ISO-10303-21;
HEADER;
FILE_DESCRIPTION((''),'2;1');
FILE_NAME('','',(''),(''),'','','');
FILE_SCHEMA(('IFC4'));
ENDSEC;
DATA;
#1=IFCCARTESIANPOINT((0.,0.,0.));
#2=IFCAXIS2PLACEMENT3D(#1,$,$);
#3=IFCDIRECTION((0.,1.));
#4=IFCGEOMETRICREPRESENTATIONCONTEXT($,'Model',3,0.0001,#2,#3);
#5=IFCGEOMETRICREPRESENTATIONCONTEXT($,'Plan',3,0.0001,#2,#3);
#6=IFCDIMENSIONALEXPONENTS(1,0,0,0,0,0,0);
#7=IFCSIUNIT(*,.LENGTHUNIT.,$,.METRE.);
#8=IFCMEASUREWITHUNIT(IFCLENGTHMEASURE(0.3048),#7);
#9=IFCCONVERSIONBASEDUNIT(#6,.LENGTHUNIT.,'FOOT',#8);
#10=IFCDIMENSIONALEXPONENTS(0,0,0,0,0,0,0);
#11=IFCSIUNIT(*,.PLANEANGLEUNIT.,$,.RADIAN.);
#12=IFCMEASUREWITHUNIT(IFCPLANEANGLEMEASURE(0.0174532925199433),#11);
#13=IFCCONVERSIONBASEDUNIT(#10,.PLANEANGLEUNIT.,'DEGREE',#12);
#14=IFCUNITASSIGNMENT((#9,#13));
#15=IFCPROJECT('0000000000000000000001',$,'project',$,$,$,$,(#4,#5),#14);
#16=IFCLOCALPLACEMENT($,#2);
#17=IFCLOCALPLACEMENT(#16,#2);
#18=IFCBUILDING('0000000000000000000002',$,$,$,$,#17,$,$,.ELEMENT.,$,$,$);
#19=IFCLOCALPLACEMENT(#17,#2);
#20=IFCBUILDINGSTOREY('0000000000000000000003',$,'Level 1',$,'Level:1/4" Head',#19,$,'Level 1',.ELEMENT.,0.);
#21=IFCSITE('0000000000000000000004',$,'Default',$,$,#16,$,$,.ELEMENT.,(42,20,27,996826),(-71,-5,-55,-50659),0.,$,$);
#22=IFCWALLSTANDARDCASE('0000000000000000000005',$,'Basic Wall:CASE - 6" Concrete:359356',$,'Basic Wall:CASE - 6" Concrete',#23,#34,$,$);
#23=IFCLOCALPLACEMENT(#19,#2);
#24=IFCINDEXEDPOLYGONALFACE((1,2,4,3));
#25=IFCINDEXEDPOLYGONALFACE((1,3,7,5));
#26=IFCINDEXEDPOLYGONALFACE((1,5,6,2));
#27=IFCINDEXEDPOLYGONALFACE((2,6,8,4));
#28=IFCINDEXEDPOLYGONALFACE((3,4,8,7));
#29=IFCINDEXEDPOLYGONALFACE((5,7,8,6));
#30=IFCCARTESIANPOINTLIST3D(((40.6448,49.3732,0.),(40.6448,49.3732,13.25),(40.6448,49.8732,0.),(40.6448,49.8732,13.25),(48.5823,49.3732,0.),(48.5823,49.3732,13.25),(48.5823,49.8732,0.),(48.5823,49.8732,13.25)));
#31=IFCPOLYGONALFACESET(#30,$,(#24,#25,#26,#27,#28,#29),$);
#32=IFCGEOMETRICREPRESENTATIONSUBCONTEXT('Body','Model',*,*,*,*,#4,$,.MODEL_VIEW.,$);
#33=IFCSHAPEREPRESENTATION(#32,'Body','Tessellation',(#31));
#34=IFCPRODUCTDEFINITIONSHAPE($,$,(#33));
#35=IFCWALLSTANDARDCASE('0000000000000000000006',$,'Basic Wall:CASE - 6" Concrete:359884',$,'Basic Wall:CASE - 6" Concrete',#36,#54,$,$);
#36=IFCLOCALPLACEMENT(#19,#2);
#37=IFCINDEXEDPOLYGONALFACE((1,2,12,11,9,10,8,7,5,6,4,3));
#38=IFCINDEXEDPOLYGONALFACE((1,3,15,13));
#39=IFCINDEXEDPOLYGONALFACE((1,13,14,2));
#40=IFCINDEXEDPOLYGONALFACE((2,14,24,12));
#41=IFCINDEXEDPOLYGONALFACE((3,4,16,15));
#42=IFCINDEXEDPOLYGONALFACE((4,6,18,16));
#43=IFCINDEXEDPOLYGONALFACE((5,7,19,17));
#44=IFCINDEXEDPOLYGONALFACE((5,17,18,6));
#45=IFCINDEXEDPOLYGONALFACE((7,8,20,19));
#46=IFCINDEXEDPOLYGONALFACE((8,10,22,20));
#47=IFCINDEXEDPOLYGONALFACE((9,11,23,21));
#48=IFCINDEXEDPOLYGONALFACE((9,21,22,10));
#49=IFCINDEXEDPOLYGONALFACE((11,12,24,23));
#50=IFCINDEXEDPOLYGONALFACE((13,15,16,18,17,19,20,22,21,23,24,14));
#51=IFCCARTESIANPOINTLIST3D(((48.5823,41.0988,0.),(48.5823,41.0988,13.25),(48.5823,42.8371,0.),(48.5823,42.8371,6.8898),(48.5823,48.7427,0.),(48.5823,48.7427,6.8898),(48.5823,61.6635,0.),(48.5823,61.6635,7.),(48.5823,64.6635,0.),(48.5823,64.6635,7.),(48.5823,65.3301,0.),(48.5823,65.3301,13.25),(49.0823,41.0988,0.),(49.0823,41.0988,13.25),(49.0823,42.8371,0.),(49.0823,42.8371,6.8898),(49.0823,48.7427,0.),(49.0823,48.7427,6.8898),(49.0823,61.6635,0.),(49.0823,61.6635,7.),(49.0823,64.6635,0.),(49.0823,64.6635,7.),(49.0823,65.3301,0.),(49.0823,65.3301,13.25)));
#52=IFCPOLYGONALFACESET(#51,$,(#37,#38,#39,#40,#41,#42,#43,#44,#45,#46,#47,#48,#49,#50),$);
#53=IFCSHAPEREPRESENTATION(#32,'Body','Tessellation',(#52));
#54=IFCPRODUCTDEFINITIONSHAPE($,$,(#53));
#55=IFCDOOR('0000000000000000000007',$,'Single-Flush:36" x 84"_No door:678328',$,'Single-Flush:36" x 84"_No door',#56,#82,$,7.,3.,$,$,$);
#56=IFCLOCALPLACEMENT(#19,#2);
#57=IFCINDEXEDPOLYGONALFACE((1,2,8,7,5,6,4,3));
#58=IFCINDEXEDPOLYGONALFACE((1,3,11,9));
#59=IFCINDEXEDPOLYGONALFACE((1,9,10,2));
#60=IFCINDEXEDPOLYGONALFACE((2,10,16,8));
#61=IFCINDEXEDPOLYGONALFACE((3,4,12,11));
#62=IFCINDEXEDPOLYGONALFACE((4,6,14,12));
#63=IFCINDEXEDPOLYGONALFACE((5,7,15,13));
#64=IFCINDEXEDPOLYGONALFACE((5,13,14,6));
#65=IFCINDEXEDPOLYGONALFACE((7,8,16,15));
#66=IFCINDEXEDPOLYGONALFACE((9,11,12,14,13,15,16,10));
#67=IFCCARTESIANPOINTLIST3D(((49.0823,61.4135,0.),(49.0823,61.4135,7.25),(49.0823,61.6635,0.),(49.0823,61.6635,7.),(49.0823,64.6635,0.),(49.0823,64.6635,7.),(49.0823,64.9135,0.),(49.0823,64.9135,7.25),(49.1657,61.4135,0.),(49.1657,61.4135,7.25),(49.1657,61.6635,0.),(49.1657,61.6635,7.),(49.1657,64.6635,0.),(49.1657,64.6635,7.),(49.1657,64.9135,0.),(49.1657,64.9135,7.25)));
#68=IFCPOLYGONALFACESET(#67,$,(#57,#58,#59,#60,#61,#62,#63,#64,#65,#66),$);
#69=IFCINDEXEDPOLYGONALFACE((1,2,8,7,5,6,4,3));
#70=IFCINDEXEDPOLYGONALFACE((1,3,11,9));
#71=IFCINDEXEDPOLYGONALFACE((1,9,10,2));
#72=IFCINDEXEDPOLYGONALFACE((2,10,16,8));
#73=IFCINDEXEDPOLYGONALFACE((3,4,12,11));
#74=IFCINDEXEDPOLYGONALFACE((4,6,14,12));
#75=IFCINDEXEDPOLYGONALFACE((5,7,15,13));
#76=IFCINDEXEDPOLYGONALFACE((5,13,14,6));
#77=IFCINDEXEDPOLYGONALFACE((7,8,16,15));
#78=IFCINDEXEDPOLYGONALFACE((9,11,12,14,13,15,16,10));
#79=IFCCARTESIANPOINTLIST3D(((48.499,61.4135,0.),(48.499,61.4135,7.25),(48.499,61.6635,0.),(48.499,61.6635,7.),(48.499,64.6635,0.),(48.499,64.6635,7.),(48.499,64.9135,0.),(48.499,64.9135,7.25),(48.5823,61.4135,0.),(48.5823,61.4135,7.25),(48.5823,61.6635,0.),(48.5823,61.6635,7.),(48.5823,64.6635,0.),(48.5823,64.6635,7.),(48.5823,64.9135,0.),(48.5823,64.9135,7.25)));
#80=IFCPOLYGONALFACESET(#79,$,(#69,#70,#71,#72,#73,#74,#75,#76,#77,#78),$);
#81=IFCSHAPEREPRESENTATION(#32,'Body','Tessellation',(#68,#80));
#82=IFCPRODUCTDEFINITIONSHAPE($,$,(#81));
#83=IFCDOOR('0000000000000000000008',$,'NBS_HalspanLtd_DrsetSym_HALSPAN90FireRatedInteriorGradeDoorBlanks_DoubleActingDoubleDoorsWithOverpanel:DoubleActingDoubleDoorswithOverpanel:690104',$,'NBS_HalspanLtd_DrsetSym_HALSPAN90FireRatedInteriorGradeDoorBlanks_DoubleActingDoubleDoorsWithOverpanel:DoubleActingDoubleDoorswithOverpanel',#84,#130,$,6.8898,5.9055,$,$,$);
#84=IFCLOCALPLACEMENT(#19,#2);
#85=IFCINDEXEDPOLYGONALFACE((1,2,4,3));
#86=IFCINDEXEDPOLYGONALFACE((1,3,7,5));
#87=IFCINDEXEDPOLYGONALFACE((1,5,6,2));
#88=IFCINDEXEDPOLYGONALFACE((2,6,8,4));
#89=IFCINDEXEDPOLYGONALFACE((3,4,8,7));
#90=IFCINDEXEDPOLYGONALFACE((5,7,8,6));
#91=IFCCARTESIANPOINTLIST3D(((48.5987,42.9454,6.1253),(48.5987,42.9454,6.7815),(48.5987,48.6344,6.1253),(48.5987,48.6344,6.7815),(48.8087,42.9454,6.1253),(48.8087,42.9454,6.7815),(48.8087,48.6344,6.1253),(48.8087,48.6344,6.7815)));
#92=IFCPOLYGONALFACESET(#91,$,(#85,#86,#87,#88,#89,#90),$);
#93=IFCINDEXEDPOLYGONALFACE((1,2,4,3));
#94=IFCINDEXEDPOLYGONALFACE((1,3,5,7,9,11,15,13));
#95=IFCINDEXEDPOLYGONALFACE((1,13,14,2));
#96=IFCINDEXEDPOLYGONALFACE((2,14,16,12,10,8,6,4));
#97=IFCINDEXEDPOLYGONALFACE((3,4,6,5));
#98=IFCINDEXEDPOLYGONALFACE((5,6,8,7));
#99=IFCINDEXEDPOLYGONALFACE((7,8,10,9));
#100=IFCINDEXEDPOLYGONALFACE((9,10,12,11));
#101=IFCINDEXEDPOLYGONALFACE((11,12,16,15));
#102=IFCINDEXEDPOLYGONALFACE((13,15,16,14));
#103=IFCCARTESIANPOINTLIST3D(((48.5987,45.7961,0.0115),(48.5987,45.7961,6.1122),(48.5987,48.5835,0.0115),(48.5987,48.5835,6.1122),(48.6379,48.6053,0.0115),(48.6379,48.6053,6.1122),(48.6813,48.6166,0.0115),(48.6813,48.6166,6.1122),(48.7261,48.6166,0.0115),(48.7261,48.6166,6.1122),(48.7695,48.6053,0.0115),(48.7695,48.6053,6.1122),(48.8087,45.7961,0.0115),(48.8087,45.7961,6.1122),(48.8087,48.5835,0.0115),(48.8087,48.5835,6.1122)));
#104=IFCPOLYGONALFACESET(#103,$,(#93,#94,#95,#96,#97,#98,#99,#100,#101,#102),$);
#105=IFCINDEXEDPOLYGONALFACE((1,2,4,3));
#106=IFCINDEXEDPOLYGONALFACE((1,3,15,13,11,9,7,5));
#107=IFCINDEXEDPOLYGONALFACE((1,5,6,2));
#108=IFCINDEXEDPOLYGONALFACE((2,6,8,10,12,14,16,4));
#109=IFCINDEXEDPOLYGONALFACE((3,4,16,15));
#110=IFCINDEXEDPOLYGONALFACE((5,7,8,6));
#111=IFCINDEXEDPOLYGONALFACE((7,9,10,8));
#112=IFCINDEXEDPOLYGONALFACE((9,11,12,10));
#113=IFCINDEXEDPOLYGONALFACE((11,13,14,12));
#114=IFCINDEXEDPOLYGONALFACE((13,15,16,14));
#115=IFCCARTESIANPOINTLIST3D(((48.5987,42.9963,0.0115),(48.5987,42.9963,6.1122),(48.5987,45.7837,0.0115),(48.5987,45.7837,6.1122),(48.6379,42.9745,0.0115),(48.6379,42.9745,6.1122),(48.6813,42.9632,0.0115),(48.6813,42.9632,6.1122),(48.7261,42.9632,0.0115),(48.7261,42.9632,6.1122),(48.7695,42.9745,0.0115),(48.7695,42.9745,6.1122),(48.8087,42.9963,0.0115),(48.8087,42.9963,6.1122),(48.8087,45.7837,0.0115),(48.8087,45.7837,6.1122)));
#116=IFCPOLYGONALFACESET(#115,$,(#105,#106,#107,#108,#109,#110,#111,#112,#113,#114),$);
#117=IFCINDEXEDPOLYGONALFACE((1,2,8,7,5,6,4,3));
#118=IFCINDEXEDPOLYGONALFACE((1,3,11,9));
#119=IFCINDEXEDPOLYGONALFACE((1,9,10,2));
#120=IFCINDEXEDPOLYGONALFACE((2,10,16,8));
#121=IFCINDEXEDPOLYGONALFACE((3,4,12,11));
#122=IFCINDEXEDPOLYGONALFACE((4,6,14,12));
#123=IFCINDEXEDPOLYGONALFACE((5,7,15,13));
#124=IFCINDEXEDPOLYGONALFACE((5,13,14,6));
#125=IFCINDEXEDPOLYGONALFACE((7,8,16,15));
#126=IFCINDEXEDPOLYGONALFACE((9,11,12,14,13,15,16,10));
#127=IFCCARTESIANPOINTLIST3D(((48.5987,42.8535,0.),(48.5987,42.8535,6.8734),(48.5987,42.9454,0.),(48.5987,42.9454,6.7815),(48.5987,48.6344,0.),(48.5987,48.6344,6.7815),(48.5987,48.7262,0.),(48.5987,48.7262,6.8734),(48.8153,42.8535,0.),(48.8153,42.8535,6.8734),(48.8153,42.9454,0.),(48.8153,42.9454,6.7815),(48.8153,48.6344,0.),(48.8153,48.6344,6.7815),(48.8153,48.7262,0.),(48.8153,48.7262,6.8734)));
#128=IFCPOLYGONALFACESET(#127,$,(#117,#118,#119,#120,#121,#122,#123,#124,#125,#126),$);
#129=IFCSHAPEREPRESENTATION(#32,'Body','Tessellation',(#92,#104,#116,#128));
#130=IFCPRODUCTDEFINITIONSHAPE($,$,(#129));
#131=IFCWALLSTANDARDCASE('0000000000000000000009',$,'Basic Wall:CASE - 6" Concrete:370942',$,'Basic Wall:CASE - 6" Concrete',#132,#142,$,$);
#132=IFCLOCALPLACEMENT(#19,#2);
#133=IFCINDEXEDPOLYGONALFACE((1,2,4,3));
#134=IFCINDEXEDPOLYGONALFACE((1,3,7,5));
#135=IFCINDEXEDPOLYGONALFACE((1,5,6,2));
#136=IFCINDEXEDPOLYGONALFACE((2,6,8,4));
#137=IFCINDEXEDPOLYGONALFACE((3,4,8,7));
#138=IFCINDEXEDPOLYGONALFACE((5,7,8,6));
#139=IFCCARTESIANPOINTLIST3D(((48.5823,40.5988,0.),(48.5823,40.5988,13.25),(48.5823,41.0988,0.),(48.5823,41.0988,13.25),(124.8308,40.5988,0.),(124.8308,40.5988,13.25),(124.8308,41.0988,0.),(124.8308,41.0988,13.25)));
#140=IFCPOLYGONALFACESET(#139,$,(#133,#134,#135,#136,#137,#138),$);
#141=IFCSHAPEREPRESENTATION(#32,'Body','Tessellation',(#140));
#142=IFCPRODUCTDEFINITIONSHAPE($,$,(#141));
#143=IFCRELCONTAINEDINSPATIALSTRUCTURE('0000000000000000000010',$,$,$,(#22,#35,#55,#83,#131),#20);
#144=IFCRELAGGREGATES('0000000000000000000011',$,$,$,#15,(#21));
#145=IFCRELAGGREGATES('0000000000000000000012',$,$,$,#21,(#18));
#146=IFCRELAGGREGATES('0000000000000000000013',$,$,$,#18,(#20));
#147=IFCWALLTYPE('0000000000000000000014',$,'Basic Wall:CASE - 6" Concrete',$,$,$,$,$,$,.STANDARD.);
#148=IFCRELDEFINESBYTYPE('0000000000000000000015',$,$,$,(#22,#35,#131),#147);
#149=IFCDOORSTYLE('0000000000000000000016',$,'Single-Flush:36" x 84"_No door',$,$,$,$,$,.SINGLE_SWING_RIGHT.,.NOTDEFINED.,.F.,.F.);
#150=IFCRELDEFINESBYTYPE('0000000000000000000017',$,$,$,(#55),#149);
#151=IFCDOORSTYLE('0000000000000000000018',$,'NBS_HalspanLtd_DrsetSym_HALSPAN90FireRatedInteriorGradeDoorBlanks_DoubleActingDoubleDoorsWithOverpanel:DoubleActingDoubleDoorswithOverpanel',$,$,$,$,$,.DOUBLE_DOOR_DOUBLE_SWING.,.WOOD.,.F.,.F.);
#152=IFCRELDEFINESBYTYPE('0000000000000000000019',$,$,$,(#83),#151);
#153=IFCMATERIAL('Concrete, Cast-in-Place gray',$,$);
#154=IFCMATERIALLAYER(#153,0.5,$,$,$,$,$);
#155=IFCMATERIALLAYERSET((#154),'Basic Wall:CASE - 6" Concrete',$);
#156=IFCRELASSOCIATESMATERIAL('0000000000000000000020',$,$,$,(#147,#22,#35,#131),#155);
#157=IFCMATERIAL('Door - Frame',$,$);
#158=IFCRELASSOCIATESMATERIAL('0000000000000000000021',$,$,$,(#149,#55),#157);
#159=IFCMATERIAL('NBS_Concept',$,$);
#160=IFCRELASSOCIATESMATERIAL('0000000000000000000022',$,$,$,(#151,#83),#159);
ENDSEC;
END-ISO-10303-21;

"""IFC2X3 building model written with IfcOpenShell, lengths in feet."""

from ifc_helpers import new_model, entity, si_unit, converted_unit, direction, frame, frame_2d, origin, place, context, subcontext, project, spatial, polyline, circle_curve, parameter, trimmed, segment, composite_curve, rectangle, outline, extrude, source, transform, mapped, material, layer, layer_set, layer_usage, type_object, type_shapes, element, fill, save


model = new_model("IFC2X3")

# Units and contexts
model_context = context("Model", 3, precision=0.0001, world=origin(), true_north=direction((0.0, 1.0)))
plan_context = context("Plan", 3, precision=0.0001, world=origin(), true_north=direction((0.0, 1.0)))
body_context = subcontext(model_context, "Body", "Model", "MODEL_VIEW")
ifc_project = project(units=[converted_unit("LENGTHUNIT", "FOOT", entity("IfcLengthMeasure", 0.3048), si_unit("LENGTHUNIT", "METRE"), dimensions=[1, 0, 0, 0, 0, 0, 0]), converted_unit("PLANEANGLEUNIT", "DEGREE", entity("IfcPlaneAngleMeasure", 0.0174532925199433), si_unit("PLANEANGLEUNIT", "RADIAN"), dimensions=[0, 0, 0, 0, 0, 0, 0])], contexts=[model_context, plan_context])

# Site, building, storey
site_placement = place(None, origin())
site = spatial("IfcSite", under=ifc_project, at=site_placement, Name="Default", CompositionType="ELEMENT", RefLatitude=(42, 20, 27, 996826), RefLongitude=(-71, -5, -55, -50659), RefElevation=0.0)
building_placement = place(site_placement, origin())
building = spatial("IfcBuilding", under=site, at=building_placement, CompositionType="ELEMENT")
storey_placement = place(building_placement, origin())
storey = spatial("IfcBuildingStorey", under=building, at=storey_placement, Name="Level 1", ObjectType="Level:1/4\" Head", LongName="Level 1", CompositionType="ELEMENT", Elevation=0.0)

# Wall
ifc_material_1 = material(Name="Concrete, Cast-in-Place gray")
ifc_layer = layer(ifc_material_1, 0.5)
ifc_layer_set = layer_set([ifc_layer], Name="Basic Wall:CASE - 6\" Concrete")
ifc_layer_usage_1 = layer_usage(ifc_layer_set, "AXIS2", "NEGATIVE", 0.25)
wall_type = type_object("IfcWallType", Name="Basic Wall:CASE - 6\" Concrete", PredefinedType="STANDARD", material=ifc_layer_set)
wall_1_placement = place(storey_placement, frame((40.6448, 49.6232, 0.0)))
element("IfcWallStandardCase", 1, at=wall_1_placement, inside=storey, type_object=wall_type, material=ifc_layer_usage_1, Name="Basic Wall:CASE - 6\" Concrete:359356", ObjectType="Basic Wall:CASE - 6\" Concrete", context=body_context, shape_type="SweptSolid", body=[
    extrude(rectangle(XDim=7.9375, YDim=0.5, at=frame_2d((3.9688, 0.0), x_axis=(-1.0, 0.0))), origin(), (0.0, 0.0, 1.0), 13.25),
])

# Wall, openings, doors
ifc_layer_usage_2 = layer_usage(ifc_layer_set, "AXIS2", "NEGATIVE", 0.25)
wall_2_placement = place(storey_placement, frame((48.8323, 41.0988, 0.0), z_axis=(0.0, 0.0, 1.0), x_axis=(0.0, 1.0, 0.0)))
wall_2 = element("IfcWallStandardCase", 2, at=wall_2_placement, inside=storey, type_object=wall_type, material=ifc_layer_usage_2, Name="Basic Wall:CASE - 6\" Concrete:359884", ObjectType="Basic Wall:CASE - 6\" Concrete", context=body_context, shape_type="SweptSolid", body=[
    extrude(rectangle(XDim=24.2313, YDim=0.5, at=frame_2d((12.1157, 0.0), x_axis=(1.0, 0.0))), origin(), (0.0, 0.0, 1.0), 13.25),
])
opening_1_placement = place(wall_2_placement, frame((23.5646, 0.25, 0.0)))
opening_1 = element("IfcOpeningElement", 3, at=opening_1_placement, cuts=wall_2, ObjectType="Opening", context=body_context, shape_type="SweptSolid", body=[
    extrude(rectangle(XDim=3.0, YDim=7.0, at=frame_2d((3.5, 1.5), x_axis=(0.0, 1.0))), frame((0.0, 0.0, 0.0), z_axis=(0.0, -1.0, 0.0), x_axis=(0.0, 0.0, 1.0)), (0.0, 0.0, 1.0), 0.5),
])
opening_2_placement = place(wall_2_placement, frame((-41.0988, 48.8323, 0.0), z_axis=(0.0, 0.0, 1.0), x_axis=(0.0, -1.0, 0.0)))
opening_2 = element("IfcOpeningElement", 4, at=opening_2_placement, cuts=wall_2, ObjectType="Opening", context=body_context, shape_type="SweptSolid", body=[
    extrude(rectangle(XDim=6.8898, YDim=5.9055, at=frame_2d((0.0, 0.0), x_axis=(0.0, 1.0))), frame((49.0987, 45.7899, 3.4449), z_axis=(-1.0, 0.0, 0.0), x_axis=(0.0, 1.0, 0.0)), (0.0, 0.0, 1.0), 0.5328),
])
ifc_material_2 = material(Name="Door - Frame")
door_style_1 = type_object("IfcDoorStyle", Name="Single-Flush:36\" x 84\"_No door", ConstructionType="NOTDEFINED", OperationType="SINGLE_SWING_RIGHT", ParameterTakesPrecedence=False, Sizeable=False, material=ifc_material_2)
shared_shape_1 = source(origin(), body_context, "Body", "SweptSolid", [
    extrude(outline(polyline([(-1.75, -3.6875), (1.75, -3.6875), (1.75, 3.5625), (1.5, 3.5625), (1.5, -3.4375), (-1.5, -3.4375), (-1.5, 3.5625), (-1.75, 3.5625), (-1.75, -3.6875)])), frame((1.5, 0.5, 3.5625), z_axis=(0.0, 1.0, 0.0), x_axis=(1.0, 0.0, 0.0)), (0.0, 0.0, 1.0), 0.0833),
    extrude(outline(polyline([(-3.6875, -1.75), (3.5625, -1.75), (3.5625, -1.5), (-3.4375, -1.5), (-3.4375, 1.5), (3.5625, 1.5), (3.5625, 1.75), (-3.6875, 1.75), (-3.6875, -1.75)])), frame((1.5, -0.0833, 3.5625), z_axis=(0.0, 1.0, 0.0), x_axis=(0.0, 0.0, -1.0)), (0.0, 0.0, 1.0), 0.0833),
])
type_shapes(door_style_1, [shared_shape_1])
door_1_placement = place(opening_1_placement, frame((0.0, 0.0, 0.0), z_axis=(0.0, 0.0, 1.0), x_axis=(-1.0, 0.0, 0.0)))
door_1 = element("IfcDoor", 5, at=door_1_placement, inside=storey, type_object=door_style_1, material=ifc_material_2, Name="Single-Flush:36\" x 84\"_No door:678328", ObjectType="Single-Flush:36\" x 84\"_No door", OverallHeight=7.0, OverallWidth=3.0, context=body_context, shape_type="MappedRepresentation", body=[
    mapped(shared_shape_1, transform((0.0, 0.0, 0.0), scale=1.0)),
])
fill(opening_1, door_1)
ifc_material_3 = material(Name="NBS_Concept")
door_style_2 = type_object("IfcDoorStyle", Name="NBS_HalspanLtd_DrsetSym_HALSPAN90FireRatedInteriorGradeDoorBlanks_DoubleActingDoubleDoorsWithOverpanel:DoubleActingDoubleDoorswithOverpanel", ConstructionType="WOOD", OperationType="DOUBLE_DOOR_DOUBLE_SWING", ParameterTakesPrecedence=False, Sizeable=False, material=ifc_material_3)
shared_shape_2 = source(origin(), body_context, "Body", "SweptSolid", [
    extrude(rectangle(XDim=5.689, YDim=0.21, at=frame_2d((0.0, 0.0), x_axis=(1.0, 0.0))), frame((2.9528, -0.1378, 6.1253), z_axis=(0.0, 0.0, 1.0), x_axis=(-1.0, 0.0, 0.0)), (0.0, 0.0, 1.0), 0.6562),
    extrude(outline(composite_curve([segment(polyline([(-0.105, -1.3937), (0.105, -1.3937)]), True, "CONTINUOUS"), segment(polyline([(0.105, -1.3937), (0.105, 1.3937)]), True, "CONTINUOUS"), segment(trimmed(circle_curve(frame_2d((0.0, 1.251), x_axis=(0.0, 1.0)), 0.1772), [parameter(323.658797)], [parameter(36.341203)], True, "PARAMETER"), True, "CONTINUOUS"), segment(polyline([(-0.105, 1.3937), (-0.105, -1.3937)]), True, "CONTINUOUS")], self_intersect=False)), frame((4.3527, -0.1378, 0.0115), z_axis=(0.0, 0.0, 1.0), x_axis=(0.0, -1.0, 0.0)), (0.0, 0.0, 1.0), 6.1007),
    extrude(outline(composite_curve([segment(polyline([(-0.105, -1.3937), (0.105, -1.3937)]), True, "CONTINUOUS"), segment(polyline([(0.105, -1.3937), (0.105, 1.3937)]), True, "CONTINUOUS"), segment(trimmed(circle_curve(frame_2d((0.0, 1.251), x_axis=(0.0, -1.0)), 0.1772), [parameter(143.658797)], [parameter(216.341203)], True, "PARAMETER"), True, "CONTINUOUS"), segment(polyline([(-0.105, 1.3937), (-0.105, -1.3937)]), True, "CONTINUOUS")], self_intersect=False)), frame((1.5528, -0.1378, 0.0115), z_axis=(0.0, 0.0, 1.0), x_axis=(0.0, 1.0, 0.0)), (0.0, 0.0, 1.0), 6.1007),
    extrude(outline(polyline([(-3.4137, -2.8445), (-3.4137, -2.9364), (3.4596, -2.9364), (3.4596, 2.9364), (-3.4137, 2.9364), (-3.4137, 2.8445), (3.3678, 2.8445), (3.3678, -2.8445), (-3.4137, -2.8445)])), frame((2.9528, -0.2493, 3.4137), z_axis=(0.0, -1.0, 0.0), x_axis=(0.0, 0.0, 1.0)), (0.0, 0.0, -1.0), 0.2165),
])
type_shapes(door_style_2, [shared_shape_2])
door_2_placement = place(opening_2_placement, frame((48.5659, 42.8371, 0.0), z_axis=(0.0, 0.0, 1.0), x_axis=(0.0, 1.0, 0.0)))
door_2 = element("IfcDoor", 6, at=door_2_placement, inside=storey, type_object=door_style_2, material=ifc_material_3, Name="NBS_HalspanLtd_DrsetSym_HALSPAN90FireRatedInteriorGradeDoorBlanks_DoubleActingDoubleDoorsWithOverpanel:DoubleActingDoubleDoorswithOverpanel:690104", ObjectType="NBS_HalspanLtd_DrsetSym_HALSPAN90FireRatedInteriorGradeDoorBlanks_DoubleActingDoubleDoorsWithOverpanel:DoubleActingDoubleDoorswithOverpanel", OverallHeight=6.8898, OverallWidth=5.9055, context=body_context, shape_type="MappedRepresentation", body=[
    mapped(shared_shape_2, transform((0.0, 0.0, 0.0), scale=1.0)),
])
fill(opening_2, door_2)

# Wall
ifc_layer_usage_3 = layer_usage(ifc_layer_set, "AXIS2", "NEGATIVE", 0.25)
wall_3_placement = place(storey_placement, frame((48.5823, 40.8488, 0.0)))
element("IfcWallStandardCase", 7, at=wall_3_placement, inside=storey, type_object=wall_type, material=ifc_layer_usage_3, Name="Basic Wall:CASE - 6\" Concrete:370942", ObjectType="Basic Wall:CASE - 6\" Concrete", context=body_context, shape_type="SweptSolid", body=[
    extrude(rectangle(XDim=76.2485, YDim=0.5, at=frame_2d((38.1243, 0.0), x_axis=(-1.0, 0.0))), origin(), (0.0, 0.0, 1.0), 13.25),
])

save(model, "model.ifc")
